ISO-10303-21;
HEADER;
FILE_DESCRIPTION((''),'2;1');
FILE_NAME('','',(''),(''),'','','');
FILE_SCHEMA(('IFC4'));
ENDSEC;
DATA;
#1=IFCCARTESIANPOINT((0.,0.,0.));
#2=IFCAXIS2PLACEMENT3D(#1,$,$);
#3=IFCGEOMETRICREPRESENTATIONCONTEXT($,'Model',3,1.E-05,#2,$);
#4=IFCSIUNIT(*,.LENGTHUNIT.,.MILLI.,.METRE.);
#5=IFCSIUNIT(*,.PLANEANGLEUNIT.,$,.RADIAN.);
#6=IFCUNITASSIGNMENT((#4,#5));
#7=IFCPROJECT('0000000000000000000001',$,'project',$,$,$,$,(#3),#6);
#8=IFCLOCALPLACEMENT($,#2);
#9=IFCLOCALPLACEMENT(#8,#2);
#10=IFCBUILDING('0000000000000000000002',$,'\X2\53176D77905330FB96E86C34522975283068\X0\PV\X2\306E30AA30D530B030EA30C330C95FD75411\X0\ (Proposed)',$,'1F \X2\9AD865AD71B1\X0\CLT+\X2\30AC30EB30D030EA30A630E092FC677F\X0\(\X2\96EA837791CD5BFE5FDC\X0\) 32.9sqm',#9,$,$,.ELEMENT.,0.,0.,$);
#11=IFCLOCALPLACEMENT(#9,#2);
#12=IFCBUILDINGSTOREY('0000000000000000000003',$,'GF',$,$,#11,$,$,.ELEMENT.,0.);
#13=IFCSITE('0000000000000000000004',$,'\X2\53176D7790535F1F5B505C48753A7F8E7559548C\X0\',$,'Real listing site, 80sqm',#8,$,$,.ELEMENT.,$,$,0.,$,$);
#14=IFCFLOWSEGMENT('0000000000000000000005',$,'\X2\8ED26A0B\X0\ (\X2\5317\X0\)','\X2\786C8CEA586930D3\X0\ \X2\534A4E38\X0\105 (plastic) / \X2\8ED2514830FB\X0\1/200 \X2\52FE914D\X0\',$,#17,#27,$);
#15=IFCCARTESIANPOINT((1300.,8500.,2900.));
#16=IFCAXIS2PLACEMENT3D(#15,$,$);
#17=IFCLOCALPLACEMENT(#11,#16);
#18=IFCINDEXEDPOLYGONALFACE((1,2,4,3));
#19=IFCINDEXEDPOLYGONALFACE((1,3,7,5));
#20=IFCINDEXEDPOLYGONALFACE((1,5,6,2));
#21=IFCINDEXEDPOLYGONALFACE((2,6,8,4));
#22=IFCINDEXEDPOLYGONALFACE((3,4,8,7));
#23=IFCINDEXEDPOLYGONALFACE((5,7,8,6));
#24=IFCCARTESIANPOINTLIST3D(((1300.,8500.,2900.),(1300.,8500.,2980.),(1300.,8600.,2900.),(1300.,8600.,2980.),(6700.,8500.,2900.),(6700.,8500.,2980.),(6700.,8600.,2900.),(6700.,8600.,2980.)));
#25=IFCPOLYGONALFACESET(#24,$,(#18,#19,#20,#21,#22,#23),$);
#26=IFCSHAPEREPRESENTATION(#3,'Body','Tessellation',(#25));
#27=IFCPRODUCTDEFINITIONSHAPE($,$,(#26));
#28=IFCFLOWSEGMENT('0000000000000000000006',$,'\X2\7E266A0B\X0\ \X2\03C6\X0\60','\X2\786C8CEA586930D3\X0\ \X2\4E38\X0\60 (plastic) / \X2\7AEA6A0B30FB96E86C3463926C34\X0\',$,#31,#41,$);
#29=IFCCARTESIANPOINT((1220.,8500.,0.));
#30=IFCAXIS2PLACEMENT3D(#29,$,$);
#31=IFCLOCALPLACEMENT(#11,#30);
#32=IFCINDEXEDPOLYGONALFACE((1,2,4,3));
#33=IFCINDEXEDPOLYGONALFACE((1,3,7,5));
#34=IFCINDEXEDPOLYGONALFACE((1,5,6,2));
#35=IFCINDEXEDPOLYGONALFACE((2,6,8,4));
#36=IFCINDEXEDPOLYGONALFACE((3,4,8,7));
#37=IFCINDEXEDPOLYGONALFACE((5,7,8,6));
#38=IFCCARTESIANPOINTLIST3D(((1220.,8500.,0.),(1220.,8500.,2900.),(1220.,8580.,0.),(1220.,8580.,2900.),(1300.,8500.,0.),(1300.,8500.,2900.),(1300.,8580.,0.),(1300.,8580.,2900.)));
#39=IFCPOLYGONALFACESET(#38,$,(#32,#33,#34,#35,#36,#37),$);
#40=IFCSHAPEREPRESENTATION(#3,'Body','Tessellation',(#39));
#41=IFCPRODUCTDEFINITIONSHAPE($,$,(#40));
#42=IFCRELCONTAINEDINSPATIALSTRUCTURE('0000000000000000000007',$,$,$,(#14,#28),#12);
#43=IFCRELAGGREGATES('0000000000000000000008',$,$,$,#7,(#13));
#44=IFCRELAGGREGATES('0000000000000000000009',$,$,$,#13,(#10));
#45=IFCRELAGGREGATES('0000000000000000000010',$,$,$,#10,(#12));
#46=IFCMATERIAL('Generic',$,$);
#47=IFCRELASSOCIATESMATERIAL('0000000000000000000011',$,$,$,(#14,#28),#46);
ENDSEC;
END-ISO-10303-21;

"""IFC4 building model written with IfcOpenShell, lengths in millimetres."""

from ifc_helpers import new_model, si_unit, frame, frame_2d, origin, place, context, project, spatial, rectangle, extrude, material, element, save


model = new_model("IFC4")

# Units and contexts
model_context = context("Model", 3, precision=1e-05, world=origin())
ifc_project = project(units=[si_unit("LENGTHUNIT", "METRE", prefix="MILLI"), si_unit("PLANEANGLEUNIT", "RADIAN")], contexts=[model_context])

# Site, building, storey
site_placement = place(None, origin())
site = spatial("IfcSite", under=ifc_project, at=site_placement, Name="北海道弟子屈町美留和", ObjectType="Real listing site, 80sqm", CompositionType="ELEMENT", RefElevation=0.0)
building_placement = place(site_placement, origin())
building = spatial("IfcBuilding", under=site, at=building_placement, Name="北海道・雨水利用とPVのオフグリッド志向 (Proposed)", ObjectType="1F 高断熱CLT+ガルバリウム鋼板(雪荷重対応) 32.9sqm", CompositionType="ELEMENT", ElevationOfRefHeight=0.0, ElevationOfTerrain=0.0)
storey_placement = place(building_placement, origin())
storey = spatial("IfcBuildingStorey", under=building, at=storey_placement, Name="GF", CompositionType="ELEMENT", Elevation=0.0)

# Shared definitions
ifc_material_1 = material(Name="Generic")

# Flow segments
flow_segment_1_placement = place(storey_placement, frame((1300.0, 8500.0, 2900.0)))
element("IfcFlowSegment", 1, at=flow_segment_1_placement, inside=storey, material=ifc_material_1, Name="軒樋 (北)", Description="硬質塩ビ 半丸105 (plastic) / 軒先・1/200 勾配", context=model_context, shape_type="SweptSolid", body=[
    extrude(rectangle(XDim=5400.0, YDim=100.0, at=frame_2d((2700.0, 50.0))), frame((1300.0, 8500.0, 2900.0)), (0.0, 0.0, 1.0), 80.0),
])
flow_segment_2_placement = place(storey_placement, frame((1220.0, 8500.0, 0.0)))
element("IfcFlowSegment", 2, at=flow_segment_2_placement, inside=storey, material=ifc_material_1, Name="縦樋 φ60", Description="硬質塩ビ 丸60 (plastic) / 竪樋・雨水排水", context=model_context, shape_type="SweptSolid", body=[
    extrude(rectangle(XDim=80.0, YDim=80.0, at=frame_2d((40.0, 40.0))), frame((1220.0, 8500.0, 0.0)), (0.0, 0.0, 1.0), 2900.0),
])

save(model, "model.ifc")
